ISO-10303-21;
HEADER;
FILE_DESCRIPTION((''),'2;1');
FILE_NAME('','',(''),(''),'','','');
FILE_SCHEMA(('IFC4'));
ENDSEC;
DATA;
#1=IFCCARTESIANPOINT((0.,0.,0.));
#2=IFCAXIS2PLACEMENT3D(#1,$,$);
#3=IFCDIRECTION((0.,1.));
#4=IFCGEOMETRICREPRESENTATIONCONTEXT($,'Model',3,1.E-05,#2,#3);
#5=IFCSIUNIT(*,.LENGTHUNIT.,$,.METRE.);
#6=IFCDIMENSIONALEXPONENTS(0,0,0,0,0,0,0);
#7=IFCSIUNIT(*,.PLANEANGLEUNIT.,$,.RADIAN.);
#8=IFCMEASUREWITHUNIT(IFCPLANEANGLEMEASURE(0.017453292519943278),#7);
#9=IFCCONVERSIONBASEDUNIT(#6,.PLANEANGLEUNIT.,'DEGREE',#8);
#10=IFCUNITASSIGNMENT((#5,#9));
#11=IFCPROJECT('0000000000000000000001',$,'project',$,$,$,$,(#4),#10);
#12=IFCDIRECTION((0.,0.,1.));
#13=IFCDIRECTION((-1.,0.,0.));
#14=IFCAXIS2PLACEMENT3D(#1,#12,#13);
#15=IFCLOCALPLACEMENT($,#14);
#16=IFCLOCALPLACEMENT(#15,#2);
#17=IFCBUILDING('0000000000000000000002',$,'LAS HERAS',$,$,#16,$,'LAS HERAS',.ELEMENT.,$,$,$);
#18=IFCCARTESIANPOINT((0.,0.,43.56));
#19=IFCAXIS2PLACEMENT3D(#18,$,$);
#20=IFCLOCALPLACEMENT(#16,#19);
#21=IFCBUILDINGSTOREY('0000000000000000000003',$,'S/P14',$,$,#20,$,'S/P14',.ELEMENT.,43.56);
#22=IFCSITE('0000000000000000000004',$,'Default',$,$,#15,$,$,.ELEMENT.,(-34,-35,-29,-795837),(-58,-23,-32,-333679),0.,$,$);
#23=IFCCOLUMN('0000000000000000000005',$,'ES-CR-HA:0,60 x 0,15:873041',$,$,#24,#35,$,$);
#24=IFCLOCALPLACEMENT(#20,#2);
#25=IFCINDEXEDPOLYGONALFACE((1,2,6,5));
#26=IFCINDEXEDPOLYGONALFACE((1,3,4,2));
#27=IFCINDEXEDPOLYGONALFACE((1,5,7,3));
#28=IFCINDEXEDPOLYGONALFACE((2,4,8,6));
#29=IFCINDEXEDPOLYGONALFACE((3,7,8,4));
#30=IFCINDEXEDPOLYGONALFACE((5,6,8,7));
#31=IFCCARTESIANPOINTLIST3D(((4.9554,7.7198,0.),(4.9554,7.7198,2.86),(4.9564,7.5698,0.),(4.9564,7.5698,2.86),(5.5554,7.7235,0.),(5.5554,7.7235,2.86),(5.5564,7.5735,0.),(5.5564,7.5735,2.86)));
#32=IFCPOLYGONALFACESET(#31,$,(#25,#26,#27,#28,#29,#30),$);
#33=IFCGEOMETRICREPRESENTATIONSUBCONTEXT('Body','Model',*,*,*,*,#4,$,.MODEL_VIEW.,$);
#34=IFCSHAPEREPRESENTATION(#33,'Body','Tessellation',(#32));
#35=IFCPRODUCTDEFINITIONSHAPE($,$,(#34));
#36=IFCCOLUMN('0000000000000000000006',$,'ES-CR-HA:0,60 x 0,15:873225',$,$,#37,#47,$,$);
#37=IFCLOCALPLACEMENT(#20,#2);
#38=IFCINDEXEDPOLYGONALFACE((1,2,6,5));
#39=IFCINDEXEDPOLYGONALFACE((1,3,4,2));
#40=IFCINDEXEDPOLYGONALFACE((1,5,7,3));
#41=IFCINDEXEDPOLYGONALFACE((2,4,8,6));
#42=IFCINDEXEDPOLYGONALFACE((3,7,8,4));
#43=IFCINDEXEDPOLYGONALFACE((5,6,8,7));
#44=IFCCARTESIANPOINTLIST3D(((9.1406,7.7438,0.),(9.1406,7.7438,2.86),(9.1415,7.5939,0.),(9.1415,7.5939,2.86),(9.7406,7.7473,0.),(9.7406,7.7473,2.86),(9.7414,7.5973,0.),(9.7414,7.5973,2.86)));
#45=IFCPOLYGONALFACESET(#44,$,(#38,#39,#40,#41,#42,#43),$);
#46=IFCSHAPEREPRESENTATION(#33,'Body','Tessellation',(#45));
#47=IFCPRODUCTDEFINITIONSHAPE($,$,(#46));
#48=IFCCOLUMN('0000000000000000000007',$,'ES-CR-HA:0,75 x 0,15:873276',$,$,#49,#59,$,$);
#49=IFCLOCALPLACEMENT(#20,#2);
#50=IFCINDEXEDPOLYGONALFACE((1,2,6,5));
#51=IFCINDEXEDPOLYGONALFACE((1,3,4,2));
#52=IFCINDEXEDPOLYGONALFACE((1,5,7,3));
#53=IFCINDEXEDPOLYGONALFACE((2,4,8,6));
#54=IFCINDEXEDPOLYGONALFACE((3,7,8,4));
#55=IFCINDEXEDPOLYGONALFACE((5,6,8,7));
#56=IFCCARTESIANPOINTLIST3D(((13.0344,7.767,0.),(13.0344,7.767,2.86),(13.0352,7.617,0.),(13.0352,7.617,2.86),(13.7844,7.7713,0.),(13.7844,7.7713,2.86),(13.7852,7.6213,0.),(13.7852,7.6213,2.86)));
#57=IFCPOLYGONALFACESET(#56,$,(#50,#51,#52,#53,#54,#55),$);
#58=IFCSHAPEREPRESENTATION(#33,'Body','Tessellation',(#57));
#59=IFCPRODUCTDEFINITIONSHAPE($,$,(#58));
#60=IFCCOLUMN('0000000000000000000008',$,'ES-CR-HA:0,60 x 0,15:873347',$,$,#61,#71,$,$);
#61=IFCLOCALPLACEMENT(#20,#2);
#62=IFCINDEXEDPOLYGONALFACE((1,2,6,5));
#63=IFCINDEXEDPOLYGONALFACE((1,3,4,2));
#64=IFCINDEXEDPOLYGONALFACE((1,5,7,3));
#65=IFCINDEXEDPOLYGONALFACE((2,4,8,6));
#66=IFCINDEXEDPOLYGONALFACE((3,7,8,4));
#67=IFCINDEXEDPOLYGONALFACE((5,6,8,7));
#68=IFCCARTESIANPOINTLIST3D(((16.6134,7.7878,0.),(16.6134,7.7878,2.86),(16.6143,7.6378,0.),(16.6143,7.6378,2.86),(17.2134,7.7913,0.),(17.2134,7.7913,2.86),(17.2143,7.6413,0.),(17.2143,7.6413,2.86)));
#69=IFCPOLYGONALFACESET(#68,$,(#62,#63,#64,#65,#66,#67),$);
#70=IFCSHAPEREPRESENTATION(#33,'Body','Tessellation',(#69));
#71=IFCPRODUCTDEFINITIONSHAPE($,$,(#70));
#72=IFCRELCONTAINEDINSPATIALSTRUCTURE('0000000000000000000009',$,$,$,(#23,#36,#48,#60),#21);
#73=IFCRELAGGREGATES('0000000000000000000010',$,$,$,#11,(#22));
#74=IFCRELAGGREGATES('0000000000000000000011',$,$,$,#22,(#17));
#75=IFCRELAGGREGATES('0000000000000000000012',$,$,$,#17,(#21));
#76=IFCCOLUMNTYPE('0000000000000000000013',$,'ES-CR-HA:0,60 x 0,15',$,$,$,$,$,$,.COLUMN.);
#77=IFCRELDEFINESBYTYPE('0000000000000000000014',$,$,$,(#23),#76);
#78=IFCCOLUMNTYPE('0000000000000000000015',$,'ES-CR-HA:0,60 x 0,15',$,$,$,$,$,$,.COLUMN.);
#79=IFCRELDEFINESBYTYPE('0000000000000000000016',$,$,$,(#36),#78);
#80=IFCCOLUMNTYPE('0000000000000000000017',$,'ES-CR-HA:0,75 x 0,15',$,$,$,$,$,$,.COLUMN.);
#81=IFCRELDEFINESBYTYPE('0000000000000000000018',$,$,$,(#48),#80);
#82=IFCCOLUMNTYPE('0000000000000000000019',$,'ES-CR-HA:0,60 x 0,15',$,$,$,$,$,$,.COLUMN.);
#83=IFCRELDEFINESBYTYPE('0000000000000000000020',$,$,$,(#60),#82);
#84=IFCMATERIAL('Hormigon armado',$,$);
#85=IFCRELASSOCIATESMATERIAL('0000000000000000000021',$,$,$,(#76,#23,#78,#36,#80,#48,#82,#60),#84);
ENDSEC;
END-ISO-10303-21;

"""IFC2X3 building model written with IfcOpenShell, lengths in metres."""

from ifc_helpers import new_model, entity, si_unit, converted_unit, direction, frame, frame_2d, origin, place, context, subcontext, project, spatial, rectangle, extrude, source, transform, mapped, material, type_object, type_shapes, element, save


model = new_model("IFC2X3")

# Units and contexts
model_context = context("Model", 3, precision=1e-05, world=origin(), true_north=direction((0.0, 1.0)))
body_context = subcontext(model_context, "Body", "Model", "MODEL_VIEW")
ifc_project = project(units=[si_unit("LENGTHUNIT", "METRE"), converted_unit("PLANEANGLEUNIT", "DEGREE", entity("IfcPlaneAngleMeasure", 0.017453292519943278), si_unit("PLANEANGLEUNIT", "RADIAN"), dimensions=[0, 0, 0, 0, 0, 0, 0])], contexts=[model_context])

# Site, building, storey
site_placement = place(None, frame((0.0, 0.0, 0.0), z_axis=(0.0, 0.0, 1.0), x_axis=(-1.0, 0.0, 0.0)))
site = spatial("IfcSite", under=ifc_project, at=site_placement, Name="Default", CompositionType="ELEMENT", RefLatitude=(-34, -35, -29, -795837), RefLongitude=(-58, -23, -32, -333679), RefElevation=0.0)
building_placement = place(site_placement, origin())
building = spatial("IfcBuilding", under=site, at=building_placement, Name="LAS HERAS", LongName="LAS HERAS", CompositionType="ELEMENT")
storey_placement = place(building_placement, frame((0.0, 0.0, 43.56)))
storey = spatial("IfcBuildingStorey", under=building, at=storey_placement, Name="S/P14", LongName="S/P14", CompositionType="ELEMENT", Elevation=43.56)

# Columns
ifc_material = material(Name="Hormigon armado")
column_type_1 = type_object("IfcColumnType", Name="ES-CR-HA:0,60 x 0,15", PredefinedType="COLUMN", material=ifc_material)
shared_shape_1 = source(origin(), body_context, "Body", "SweptSolid", [
    extrude(rectangle(XDim=0.6, YDim=0.15, at=frame_2d((0.0, 0.0), x_axis=(1.0, 0.0))), frame((5.2559, 7.6467, 43.56), z_axis=(0.0, 0.0, 1.0), x_axis=(0.999981, 0.006192, 0.0)), (0.0, 0.0, 1.0), 2.86),
])
type_shapes(column_type_1, [shared_shape_1])
column_1_placement = place(storey_placement, frame((0.0, 0.0, -43.56)))
element("IfcColumn", 1, at=column_1_placement, inside=storey, type_object=column_type_1, material=ifc_material, Name="ES-CR-HA:0,60 x 0,15:873041", context=body_context, shape_type="MappedRepresentation", body=[
    mapped(shared_shape_1, transform((0.0, 0.0, 0.0), scale=1.0)),
])
column_type_2 = type_object("IfcColumnType", Name="ES-CR-HA:0,60 x 0,15", PredefinedType="COLUMN", material=ifc_material)
shared_shape_2 = source(origin(), body_context, "Body", "SweptSolid", [
    extrude(rectangle(XDim=0.6, YDim=0.15, at=frame_2d((0.0, 0.0), x_axis=(1.0, 0.0))), frame((9.441, 7.6706, 43.56), z_axis=(0.0, 0.0, 1.0), x_axis=(0.999983, 0.005788, 0.0)), (0.0, 0.0, 1.0), 2.86),
])
type_shapes(column_type_2, [shared_shape_2])
column_2_placement = place(storey_placement, frame((0.0, 0.0, -43.56)))
element("IfcColumn", 2, at=column_2_placement, inside=storey, type_object=column_type_2, material=ifc_material, Name="ES-CR-HA:0,60 x 0,15:873225", context=body_context, shape_type="MappedRepresentation", body=[
    mapped(shared_shape_2, transform((0.0, 0.0, 0.0), scale=1.0)),
])
column_type_3 = type_object("IfcColumnType", Name="ES-CR-HA:0,75 x 0,15", PredefinedType="COLUMN", material=ifc_material)
shared_shape_3 = source(origin(), body_context, "Body", "SweptSolid", [
    extrude(rectangle(XDim=0.75, YDim=0.15, at=frame_2d((0.0, 0.0), x_axis=(1.0, 0.0))), frame((13.4098, 7.6942, 43.56), z_axis=(0.0, 0.0, 1.0), x_axis=(0.999983, 0.005788, 0.0)), (0.0, 0.0, 1.0), 2.86),
])
type_shapes(column_type_3, [shared_shape_3])
column_3_placement = place(storey_placement, frame((0.0, 0.0, -43.56)))
element("IfcColumn", 3, at=column_3_placement, inside=storey, type_object=column_type_3, material=ifc_material, Name="ES-CR-HA:0,75 x 0,15:873276", context=body_context, shape_type="MappedRepresentation", body=[
    mapped(shared_shape_3, transform((0.0, 0.0, 0.0), scale=1.0)),
])
column_type_4 = type_object("IfcColumnType", Name="ES-CR-HA:0,60 x 0,15", PredefinedType="COLUMN", material=ifc_material)
shared_shape_4 = source(origin(), body_context, "Body", "SweptSolid", [
    extrude(rectangle(XDim=0.6, YDim=0.15, at=frame_2d((0.0, 0.0), x_axis=(1.0, 0.0))), frame((16.9139, 7.7146, 43.56), z_axis=(0.0, 0.0, 1.0), x_axis=(0.999983, 0.005788, 0.0)), (0.0, 0.0, 1.0), 2.86),
])
type_shapes(column_type_4, [shared_shape_4])
column_4_placement = place(storey_placement, frame((0.0, 0.0, -43.56)))
element("IfcColumn", 4, at=column_4_placement, inside=storey, type_object=column_type_4, material=ifc_material, Name="ES-CR-HA:0,60 x 0,15:873347", context=body_context, shape_type="MappedRepresentation", body=[
    mapped(shared_shape_4, transform((0.0, 0.0, 0.0), scale=1.0)),
])

save(model, "model.ifc")
